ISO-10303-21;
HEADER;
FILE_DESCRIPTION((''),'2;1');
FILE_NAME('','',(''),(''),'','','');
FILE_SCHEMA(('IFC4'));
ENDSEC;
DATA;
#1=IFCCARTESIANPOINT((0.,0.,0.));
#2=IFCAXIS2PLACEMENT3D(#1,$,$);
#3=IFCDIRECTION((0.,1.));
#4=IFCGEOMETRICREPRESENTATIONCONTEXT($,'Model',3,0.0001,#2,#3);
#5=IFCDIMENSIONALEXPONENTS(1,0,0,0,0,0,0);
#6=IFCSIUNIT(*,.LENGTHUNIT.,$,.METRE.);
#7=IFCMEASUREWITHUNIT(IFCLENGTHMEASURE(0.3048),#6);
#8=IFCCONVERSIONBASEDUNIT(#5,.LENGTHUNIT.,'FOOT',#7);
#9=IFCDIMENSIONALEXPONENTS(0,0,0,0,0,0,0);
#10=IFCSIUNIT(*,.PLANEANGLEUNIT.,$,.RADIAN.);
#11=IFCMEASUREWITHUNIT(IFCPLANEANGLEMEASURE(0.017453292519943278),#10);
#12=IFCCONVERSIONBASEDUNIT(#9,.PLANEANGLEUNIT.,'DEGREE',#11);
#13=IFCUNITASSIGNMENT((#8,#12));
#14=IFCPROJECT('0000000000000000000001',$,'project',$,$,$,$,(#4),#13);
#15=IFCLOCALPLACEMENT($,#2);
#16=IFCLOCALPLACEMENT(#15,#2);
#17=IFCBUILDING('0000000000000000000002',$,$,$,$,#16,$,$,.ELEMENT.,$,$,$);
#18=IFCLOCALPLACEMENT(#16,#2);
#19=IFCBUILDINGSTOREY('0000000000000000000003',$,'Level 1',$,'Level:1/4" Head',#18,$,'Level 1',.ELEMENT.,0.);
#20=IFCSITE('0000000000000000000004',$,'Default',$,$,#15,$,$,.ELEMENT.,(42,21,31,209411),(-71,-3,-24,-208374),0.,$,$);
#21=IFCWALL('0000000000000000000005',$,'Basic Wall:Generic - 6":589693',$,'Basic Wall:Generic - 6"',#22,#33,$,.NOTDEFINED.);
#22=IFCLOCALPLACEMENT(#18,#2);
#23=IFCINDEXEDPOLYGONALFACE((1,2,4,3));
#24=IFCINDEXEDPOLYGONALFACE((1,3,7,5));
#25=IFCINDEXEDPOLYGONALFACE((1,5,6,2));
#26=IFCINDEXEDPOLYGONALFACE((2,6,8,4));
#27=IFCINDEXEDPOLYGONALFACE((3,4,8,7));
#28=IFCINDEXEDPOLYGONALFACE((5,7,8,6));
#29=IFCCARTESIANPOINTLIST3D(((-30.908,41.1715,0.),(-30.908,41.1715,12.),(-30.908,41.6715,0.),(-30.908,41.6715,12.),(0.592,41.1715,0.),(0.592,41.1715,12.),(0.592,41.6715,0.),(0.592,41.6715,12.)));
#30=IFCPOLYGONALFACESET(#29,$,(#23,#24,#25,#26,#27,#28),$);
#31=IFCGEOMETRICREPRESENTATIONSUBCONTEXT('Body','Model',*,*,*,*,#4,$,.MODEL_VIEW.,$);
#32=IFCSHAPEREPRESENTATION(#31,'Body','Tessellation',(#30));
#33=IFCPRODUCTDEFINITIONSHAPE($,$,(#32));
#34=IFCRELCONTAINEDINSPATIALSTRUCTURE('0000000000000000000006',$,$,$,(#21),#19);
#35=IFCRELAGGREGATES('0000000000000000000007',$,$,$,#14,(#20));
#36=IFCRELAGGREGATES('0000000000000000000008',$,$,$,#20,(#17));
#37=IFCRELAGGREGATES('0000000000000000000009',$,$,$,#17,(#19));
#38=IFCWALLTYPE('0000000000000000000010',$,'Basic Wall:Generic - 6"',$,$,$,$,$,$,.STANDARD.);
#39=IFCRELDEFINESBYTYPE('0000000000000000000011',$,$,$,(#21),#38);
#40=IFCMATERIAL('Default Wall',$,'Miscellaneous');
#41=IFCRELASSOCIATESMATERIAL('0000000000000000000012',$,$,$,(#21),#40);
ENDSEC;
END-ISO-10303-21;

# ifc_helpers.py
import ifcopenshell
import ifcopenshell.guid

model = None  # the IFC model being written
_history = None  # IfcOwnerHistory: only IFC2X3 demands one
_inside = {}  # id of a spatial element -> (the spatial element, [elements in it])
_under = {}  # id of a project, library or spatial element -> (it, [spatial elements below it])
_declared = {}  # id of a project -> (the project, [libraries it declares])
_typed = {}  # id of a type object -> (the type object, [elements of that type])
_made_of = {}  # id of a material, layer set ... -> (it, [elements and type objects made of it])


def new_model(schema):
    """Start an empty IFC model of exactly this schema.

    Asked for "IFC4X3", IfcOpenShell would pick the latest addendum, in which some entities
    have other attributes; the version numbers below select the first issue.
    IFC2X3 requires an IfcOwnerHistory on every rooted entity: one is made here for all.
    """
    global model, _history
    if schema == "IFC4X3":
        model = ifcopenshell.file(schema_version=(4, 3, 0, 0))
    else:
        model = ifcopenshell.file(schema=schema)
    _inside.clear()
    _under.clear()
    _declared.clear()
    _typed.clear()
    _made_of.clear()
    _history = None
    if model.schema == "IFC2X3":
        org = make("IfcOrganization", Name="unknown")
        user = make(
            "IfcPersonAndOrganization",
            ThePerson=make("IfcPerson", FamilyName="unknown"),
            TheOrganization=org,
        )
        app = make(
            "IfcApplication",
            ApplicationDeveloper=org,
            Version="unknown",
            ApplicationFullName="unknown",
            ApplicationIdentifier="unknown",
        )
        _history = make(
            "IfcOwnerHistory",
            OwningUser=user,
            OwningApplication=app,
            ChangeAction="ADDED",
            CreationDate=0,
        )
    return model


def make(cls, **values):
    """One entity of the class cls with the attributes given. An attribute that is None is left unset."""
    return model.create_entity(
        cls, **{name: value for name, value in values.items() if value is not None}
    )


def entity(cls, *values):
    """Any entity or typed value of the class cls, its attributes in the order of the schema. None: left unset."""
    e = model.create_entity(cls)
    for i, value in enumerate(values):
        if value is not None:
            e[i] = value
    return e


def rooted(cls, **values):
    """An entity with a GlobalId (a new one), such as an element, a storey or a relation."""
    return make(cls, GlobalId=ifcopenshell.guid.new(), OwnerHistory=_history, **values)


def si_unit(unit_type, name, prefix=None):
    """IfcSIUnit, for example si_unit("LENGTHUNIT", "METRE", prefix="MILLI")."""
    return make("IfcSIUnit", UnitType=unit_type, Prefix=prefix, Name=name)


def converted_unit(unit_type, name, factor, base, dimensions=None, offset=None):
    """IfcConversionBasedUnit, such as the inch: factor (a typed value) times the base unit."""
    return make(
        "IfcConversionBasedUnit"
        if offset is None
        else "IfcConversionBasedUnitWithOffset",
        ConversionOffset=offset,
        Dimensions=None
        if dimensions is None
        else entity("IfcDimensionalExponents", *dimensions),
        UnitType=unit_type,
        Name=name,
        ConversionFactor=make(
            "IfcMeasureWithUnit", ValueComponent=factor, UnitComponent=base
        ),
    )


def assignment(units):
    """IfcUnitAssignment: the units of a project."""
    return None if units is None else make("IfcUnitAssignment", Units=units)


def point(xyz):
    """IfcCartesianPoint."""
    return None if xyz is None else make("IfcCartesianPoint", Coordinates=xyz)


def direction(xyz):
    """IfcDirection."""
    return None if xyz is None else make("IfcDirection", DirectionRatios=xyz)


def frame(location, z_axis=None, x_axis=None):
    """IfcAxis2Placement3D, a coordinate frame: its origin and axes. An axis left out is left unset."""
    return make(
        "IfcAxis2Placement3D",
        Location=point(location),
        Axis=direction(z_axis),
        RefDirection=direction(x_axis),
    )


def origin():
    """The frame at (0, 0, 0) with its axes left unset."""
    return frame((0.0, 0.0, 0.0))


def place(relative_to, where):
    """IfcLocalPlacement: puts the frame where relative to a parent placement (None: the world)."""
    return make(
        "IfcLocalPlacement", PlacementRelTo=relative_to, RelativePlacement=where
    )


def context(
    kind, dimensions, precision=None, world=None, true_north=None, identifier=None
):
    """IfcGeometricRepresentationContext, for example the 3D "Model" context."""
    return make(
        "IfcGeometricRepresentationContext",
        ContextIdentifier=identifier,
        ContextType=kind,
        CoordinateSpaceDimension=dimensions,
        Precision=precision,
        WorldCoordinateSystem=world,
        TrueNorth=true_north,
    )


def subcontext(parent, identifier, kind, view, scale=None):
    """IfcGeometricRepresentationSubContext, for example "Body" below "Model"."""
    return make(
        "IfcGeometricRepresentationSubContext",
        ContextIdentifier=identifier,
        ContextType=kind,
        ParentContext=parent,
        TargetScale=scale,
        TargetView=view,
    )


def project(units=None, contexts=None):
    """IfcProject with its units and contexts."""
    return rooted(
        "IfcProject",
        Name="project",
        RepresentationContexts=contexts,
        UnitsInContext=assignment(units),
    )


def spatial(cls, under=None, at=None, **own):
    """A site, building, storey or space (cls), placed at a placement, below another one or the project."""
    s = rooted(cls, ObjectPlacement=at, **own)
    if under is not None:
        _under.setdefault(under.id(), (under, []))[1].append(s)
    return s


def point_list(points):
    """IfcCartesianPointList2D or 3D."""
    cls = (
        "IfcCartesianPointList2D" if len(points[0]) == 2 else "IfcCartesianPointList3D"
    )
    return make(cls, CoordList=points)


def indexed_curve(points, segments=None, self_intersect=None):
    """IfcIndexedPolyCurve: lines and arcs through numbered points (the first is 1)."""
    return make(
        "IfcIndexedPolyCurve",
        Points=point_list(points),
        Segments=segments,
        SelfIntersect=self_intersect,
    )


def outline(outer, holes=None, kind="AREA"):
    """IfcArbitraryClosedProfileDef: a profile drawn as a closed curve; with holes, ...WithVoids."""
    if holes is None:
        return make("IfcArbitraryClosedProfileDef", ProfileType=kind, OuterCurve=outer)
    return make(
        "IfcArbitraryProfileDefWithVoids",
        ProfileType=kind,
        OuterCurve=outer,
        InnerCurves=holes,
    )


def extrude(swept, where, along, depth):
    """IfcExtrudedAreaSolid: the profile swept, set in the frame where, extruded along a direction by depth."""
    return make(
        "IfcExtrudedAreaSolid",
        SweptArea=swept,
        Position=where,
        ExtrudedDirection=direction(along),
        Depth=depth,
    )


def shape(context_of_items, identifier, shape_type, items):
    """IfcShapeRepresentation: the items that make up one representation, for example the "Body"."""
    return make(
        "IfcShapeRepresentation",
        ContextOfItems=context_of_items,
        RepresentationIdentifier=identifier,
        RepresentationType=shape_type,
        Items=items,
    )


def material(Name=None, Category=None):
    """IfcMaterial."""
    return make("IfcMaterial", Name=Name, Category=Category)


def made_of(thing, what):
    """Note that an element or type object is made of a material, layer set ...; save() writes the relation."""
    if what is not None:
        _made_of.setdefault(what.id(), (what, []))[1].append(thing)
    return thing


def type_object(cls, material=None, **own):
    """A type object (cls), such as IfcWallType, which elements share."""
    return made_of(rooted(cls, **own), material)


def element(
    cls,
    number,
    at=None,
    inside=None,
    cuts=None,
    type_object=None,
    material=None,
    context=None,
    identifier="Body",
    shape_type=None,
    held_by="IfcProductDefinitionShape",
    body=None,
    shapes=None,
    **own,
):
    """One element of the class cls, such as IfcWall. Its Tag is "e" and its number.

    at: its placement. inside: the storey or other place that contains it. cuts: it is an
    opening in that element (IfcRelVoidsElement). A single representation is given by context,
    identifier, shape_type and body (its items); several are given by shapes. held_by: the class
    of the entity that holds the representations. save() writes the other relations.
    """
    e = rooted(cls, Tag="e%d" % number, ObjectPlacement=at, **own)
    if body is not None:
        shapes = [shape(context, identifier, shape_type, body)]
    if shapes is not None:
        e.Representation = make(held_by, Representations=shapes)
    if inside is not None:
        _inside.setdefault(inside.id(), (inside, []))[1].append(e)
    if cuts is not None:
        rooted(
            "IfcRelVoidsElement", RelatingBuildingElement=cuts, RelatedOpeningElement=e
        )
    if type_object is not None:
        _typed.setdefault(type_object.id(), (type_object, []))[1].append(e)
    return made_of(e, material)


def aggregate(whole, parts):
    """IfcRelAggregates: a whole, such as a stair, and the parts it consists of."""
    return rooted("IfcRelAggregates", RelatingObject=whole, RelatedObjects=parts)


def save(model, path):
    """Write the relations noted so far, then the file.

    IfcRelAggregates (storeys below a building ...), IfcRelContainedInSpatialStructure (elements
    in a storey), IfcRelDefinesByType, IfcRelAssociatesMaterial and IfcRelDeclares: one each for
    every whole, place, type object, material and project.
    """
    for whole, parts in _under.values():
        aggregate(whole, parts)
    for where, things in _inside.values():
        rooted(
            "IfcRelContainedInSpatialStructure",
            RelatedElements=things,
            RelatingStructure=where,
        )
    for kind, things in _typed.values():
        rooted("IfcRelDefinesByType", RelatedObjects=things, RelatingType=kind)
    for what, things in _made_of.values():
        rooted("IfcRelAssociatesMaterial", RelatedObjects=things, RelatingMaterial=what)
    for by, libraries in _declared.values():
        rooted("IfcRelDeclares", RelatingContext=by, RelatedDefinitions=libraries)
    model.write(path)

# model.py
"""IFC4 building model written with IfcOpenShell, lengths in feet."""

from ifc_helpers import new_model, entity, si_unit, converted_unit, direction, frame, origin, place, context, subcontext, project, spatial, indexed_curve, outline, extrude, material, type_object, element, save


model = new_model("IFC4")

# Units and contexts
model_context = context("Model", 3, precision=0.0001, world=origin(), true_north=direction((0.0, 1.0)))
body_context = subcontext(model_context, "Body", "Model", "MODEL_VIEW")
ifc_project = project(units=[converted_unit("LENGTHUNIT", "FOOT", entity("IfcLengthMeasure", 0.3048), si_unit("LENGTHUNIT", "METRE"), dimensions=[1, 0, 0, 0, 0, 0, 0]), converted_unit("PLANEANGLEUNIT", "DEGREE", entity("IfcPlaneAngleMeasure", 0.017453292519943278), si_unit("PLANEANGLEUNIT", "RADIAN"), dimensions=[0, 0, 0, 0, 0, 0, 0])], contexts=[model_context])

# Site, building, storey
site_placement = place(None, origin())
site = spatial("IfcSite", under=ifc_project, at=site_placement, Name="Default", CompositionType="ELEMENT", RefLatitude=(42, 21, 31, 209411), RefLongitude=(-71, -3, -24, -208374), RefElevation=0.0)
building_placement = place(site_placement, origin())
building = spatial("IfcBuilding", under=site, at=building_placement, CompositionType="ELEMENT")
storey_placement = place(building_placement, origin())
storey = spatial("IfcBuildingStorey", under=building, at=storey_placement, Name="Level 1", ObjectType="Level:1/4\" Head", LongName="Level 1", CompositionType="ELEMENT", Elevation=0.0)

# Wall
ifc_material = material(Name="Default Wall", Category="Miscellaneous")
wall_type = type_object("IfcWallType", Name="Basic Wall:Generic - 6\"", PredefinedType="STANDARD")
wall_placement = place(storey_placement, frame((-30.908, 41.4215, 0.0)))
element("IfcWall", 1, at=wall_placement, inside=storey, type_object=wall_type, material=ifc_material, Name="Basic Wall:Generic - 6\":589693", ObjectType="Basic Wall:Generic - 6\"", PredefinedType="NOTDEFINED", context=body_context, shape_type="SweptSolid", body=[
    extrude(outline(indexed_curve([(31.5, 0.25), (0.0, 0.25), (0.0, -0.25), (31.5, -0.25), (31.5, 0.25)], self_intersect=False)), origin(), (0.0, 0.0, 1.0), 12.0),
])

save(model, "model.ifc")
